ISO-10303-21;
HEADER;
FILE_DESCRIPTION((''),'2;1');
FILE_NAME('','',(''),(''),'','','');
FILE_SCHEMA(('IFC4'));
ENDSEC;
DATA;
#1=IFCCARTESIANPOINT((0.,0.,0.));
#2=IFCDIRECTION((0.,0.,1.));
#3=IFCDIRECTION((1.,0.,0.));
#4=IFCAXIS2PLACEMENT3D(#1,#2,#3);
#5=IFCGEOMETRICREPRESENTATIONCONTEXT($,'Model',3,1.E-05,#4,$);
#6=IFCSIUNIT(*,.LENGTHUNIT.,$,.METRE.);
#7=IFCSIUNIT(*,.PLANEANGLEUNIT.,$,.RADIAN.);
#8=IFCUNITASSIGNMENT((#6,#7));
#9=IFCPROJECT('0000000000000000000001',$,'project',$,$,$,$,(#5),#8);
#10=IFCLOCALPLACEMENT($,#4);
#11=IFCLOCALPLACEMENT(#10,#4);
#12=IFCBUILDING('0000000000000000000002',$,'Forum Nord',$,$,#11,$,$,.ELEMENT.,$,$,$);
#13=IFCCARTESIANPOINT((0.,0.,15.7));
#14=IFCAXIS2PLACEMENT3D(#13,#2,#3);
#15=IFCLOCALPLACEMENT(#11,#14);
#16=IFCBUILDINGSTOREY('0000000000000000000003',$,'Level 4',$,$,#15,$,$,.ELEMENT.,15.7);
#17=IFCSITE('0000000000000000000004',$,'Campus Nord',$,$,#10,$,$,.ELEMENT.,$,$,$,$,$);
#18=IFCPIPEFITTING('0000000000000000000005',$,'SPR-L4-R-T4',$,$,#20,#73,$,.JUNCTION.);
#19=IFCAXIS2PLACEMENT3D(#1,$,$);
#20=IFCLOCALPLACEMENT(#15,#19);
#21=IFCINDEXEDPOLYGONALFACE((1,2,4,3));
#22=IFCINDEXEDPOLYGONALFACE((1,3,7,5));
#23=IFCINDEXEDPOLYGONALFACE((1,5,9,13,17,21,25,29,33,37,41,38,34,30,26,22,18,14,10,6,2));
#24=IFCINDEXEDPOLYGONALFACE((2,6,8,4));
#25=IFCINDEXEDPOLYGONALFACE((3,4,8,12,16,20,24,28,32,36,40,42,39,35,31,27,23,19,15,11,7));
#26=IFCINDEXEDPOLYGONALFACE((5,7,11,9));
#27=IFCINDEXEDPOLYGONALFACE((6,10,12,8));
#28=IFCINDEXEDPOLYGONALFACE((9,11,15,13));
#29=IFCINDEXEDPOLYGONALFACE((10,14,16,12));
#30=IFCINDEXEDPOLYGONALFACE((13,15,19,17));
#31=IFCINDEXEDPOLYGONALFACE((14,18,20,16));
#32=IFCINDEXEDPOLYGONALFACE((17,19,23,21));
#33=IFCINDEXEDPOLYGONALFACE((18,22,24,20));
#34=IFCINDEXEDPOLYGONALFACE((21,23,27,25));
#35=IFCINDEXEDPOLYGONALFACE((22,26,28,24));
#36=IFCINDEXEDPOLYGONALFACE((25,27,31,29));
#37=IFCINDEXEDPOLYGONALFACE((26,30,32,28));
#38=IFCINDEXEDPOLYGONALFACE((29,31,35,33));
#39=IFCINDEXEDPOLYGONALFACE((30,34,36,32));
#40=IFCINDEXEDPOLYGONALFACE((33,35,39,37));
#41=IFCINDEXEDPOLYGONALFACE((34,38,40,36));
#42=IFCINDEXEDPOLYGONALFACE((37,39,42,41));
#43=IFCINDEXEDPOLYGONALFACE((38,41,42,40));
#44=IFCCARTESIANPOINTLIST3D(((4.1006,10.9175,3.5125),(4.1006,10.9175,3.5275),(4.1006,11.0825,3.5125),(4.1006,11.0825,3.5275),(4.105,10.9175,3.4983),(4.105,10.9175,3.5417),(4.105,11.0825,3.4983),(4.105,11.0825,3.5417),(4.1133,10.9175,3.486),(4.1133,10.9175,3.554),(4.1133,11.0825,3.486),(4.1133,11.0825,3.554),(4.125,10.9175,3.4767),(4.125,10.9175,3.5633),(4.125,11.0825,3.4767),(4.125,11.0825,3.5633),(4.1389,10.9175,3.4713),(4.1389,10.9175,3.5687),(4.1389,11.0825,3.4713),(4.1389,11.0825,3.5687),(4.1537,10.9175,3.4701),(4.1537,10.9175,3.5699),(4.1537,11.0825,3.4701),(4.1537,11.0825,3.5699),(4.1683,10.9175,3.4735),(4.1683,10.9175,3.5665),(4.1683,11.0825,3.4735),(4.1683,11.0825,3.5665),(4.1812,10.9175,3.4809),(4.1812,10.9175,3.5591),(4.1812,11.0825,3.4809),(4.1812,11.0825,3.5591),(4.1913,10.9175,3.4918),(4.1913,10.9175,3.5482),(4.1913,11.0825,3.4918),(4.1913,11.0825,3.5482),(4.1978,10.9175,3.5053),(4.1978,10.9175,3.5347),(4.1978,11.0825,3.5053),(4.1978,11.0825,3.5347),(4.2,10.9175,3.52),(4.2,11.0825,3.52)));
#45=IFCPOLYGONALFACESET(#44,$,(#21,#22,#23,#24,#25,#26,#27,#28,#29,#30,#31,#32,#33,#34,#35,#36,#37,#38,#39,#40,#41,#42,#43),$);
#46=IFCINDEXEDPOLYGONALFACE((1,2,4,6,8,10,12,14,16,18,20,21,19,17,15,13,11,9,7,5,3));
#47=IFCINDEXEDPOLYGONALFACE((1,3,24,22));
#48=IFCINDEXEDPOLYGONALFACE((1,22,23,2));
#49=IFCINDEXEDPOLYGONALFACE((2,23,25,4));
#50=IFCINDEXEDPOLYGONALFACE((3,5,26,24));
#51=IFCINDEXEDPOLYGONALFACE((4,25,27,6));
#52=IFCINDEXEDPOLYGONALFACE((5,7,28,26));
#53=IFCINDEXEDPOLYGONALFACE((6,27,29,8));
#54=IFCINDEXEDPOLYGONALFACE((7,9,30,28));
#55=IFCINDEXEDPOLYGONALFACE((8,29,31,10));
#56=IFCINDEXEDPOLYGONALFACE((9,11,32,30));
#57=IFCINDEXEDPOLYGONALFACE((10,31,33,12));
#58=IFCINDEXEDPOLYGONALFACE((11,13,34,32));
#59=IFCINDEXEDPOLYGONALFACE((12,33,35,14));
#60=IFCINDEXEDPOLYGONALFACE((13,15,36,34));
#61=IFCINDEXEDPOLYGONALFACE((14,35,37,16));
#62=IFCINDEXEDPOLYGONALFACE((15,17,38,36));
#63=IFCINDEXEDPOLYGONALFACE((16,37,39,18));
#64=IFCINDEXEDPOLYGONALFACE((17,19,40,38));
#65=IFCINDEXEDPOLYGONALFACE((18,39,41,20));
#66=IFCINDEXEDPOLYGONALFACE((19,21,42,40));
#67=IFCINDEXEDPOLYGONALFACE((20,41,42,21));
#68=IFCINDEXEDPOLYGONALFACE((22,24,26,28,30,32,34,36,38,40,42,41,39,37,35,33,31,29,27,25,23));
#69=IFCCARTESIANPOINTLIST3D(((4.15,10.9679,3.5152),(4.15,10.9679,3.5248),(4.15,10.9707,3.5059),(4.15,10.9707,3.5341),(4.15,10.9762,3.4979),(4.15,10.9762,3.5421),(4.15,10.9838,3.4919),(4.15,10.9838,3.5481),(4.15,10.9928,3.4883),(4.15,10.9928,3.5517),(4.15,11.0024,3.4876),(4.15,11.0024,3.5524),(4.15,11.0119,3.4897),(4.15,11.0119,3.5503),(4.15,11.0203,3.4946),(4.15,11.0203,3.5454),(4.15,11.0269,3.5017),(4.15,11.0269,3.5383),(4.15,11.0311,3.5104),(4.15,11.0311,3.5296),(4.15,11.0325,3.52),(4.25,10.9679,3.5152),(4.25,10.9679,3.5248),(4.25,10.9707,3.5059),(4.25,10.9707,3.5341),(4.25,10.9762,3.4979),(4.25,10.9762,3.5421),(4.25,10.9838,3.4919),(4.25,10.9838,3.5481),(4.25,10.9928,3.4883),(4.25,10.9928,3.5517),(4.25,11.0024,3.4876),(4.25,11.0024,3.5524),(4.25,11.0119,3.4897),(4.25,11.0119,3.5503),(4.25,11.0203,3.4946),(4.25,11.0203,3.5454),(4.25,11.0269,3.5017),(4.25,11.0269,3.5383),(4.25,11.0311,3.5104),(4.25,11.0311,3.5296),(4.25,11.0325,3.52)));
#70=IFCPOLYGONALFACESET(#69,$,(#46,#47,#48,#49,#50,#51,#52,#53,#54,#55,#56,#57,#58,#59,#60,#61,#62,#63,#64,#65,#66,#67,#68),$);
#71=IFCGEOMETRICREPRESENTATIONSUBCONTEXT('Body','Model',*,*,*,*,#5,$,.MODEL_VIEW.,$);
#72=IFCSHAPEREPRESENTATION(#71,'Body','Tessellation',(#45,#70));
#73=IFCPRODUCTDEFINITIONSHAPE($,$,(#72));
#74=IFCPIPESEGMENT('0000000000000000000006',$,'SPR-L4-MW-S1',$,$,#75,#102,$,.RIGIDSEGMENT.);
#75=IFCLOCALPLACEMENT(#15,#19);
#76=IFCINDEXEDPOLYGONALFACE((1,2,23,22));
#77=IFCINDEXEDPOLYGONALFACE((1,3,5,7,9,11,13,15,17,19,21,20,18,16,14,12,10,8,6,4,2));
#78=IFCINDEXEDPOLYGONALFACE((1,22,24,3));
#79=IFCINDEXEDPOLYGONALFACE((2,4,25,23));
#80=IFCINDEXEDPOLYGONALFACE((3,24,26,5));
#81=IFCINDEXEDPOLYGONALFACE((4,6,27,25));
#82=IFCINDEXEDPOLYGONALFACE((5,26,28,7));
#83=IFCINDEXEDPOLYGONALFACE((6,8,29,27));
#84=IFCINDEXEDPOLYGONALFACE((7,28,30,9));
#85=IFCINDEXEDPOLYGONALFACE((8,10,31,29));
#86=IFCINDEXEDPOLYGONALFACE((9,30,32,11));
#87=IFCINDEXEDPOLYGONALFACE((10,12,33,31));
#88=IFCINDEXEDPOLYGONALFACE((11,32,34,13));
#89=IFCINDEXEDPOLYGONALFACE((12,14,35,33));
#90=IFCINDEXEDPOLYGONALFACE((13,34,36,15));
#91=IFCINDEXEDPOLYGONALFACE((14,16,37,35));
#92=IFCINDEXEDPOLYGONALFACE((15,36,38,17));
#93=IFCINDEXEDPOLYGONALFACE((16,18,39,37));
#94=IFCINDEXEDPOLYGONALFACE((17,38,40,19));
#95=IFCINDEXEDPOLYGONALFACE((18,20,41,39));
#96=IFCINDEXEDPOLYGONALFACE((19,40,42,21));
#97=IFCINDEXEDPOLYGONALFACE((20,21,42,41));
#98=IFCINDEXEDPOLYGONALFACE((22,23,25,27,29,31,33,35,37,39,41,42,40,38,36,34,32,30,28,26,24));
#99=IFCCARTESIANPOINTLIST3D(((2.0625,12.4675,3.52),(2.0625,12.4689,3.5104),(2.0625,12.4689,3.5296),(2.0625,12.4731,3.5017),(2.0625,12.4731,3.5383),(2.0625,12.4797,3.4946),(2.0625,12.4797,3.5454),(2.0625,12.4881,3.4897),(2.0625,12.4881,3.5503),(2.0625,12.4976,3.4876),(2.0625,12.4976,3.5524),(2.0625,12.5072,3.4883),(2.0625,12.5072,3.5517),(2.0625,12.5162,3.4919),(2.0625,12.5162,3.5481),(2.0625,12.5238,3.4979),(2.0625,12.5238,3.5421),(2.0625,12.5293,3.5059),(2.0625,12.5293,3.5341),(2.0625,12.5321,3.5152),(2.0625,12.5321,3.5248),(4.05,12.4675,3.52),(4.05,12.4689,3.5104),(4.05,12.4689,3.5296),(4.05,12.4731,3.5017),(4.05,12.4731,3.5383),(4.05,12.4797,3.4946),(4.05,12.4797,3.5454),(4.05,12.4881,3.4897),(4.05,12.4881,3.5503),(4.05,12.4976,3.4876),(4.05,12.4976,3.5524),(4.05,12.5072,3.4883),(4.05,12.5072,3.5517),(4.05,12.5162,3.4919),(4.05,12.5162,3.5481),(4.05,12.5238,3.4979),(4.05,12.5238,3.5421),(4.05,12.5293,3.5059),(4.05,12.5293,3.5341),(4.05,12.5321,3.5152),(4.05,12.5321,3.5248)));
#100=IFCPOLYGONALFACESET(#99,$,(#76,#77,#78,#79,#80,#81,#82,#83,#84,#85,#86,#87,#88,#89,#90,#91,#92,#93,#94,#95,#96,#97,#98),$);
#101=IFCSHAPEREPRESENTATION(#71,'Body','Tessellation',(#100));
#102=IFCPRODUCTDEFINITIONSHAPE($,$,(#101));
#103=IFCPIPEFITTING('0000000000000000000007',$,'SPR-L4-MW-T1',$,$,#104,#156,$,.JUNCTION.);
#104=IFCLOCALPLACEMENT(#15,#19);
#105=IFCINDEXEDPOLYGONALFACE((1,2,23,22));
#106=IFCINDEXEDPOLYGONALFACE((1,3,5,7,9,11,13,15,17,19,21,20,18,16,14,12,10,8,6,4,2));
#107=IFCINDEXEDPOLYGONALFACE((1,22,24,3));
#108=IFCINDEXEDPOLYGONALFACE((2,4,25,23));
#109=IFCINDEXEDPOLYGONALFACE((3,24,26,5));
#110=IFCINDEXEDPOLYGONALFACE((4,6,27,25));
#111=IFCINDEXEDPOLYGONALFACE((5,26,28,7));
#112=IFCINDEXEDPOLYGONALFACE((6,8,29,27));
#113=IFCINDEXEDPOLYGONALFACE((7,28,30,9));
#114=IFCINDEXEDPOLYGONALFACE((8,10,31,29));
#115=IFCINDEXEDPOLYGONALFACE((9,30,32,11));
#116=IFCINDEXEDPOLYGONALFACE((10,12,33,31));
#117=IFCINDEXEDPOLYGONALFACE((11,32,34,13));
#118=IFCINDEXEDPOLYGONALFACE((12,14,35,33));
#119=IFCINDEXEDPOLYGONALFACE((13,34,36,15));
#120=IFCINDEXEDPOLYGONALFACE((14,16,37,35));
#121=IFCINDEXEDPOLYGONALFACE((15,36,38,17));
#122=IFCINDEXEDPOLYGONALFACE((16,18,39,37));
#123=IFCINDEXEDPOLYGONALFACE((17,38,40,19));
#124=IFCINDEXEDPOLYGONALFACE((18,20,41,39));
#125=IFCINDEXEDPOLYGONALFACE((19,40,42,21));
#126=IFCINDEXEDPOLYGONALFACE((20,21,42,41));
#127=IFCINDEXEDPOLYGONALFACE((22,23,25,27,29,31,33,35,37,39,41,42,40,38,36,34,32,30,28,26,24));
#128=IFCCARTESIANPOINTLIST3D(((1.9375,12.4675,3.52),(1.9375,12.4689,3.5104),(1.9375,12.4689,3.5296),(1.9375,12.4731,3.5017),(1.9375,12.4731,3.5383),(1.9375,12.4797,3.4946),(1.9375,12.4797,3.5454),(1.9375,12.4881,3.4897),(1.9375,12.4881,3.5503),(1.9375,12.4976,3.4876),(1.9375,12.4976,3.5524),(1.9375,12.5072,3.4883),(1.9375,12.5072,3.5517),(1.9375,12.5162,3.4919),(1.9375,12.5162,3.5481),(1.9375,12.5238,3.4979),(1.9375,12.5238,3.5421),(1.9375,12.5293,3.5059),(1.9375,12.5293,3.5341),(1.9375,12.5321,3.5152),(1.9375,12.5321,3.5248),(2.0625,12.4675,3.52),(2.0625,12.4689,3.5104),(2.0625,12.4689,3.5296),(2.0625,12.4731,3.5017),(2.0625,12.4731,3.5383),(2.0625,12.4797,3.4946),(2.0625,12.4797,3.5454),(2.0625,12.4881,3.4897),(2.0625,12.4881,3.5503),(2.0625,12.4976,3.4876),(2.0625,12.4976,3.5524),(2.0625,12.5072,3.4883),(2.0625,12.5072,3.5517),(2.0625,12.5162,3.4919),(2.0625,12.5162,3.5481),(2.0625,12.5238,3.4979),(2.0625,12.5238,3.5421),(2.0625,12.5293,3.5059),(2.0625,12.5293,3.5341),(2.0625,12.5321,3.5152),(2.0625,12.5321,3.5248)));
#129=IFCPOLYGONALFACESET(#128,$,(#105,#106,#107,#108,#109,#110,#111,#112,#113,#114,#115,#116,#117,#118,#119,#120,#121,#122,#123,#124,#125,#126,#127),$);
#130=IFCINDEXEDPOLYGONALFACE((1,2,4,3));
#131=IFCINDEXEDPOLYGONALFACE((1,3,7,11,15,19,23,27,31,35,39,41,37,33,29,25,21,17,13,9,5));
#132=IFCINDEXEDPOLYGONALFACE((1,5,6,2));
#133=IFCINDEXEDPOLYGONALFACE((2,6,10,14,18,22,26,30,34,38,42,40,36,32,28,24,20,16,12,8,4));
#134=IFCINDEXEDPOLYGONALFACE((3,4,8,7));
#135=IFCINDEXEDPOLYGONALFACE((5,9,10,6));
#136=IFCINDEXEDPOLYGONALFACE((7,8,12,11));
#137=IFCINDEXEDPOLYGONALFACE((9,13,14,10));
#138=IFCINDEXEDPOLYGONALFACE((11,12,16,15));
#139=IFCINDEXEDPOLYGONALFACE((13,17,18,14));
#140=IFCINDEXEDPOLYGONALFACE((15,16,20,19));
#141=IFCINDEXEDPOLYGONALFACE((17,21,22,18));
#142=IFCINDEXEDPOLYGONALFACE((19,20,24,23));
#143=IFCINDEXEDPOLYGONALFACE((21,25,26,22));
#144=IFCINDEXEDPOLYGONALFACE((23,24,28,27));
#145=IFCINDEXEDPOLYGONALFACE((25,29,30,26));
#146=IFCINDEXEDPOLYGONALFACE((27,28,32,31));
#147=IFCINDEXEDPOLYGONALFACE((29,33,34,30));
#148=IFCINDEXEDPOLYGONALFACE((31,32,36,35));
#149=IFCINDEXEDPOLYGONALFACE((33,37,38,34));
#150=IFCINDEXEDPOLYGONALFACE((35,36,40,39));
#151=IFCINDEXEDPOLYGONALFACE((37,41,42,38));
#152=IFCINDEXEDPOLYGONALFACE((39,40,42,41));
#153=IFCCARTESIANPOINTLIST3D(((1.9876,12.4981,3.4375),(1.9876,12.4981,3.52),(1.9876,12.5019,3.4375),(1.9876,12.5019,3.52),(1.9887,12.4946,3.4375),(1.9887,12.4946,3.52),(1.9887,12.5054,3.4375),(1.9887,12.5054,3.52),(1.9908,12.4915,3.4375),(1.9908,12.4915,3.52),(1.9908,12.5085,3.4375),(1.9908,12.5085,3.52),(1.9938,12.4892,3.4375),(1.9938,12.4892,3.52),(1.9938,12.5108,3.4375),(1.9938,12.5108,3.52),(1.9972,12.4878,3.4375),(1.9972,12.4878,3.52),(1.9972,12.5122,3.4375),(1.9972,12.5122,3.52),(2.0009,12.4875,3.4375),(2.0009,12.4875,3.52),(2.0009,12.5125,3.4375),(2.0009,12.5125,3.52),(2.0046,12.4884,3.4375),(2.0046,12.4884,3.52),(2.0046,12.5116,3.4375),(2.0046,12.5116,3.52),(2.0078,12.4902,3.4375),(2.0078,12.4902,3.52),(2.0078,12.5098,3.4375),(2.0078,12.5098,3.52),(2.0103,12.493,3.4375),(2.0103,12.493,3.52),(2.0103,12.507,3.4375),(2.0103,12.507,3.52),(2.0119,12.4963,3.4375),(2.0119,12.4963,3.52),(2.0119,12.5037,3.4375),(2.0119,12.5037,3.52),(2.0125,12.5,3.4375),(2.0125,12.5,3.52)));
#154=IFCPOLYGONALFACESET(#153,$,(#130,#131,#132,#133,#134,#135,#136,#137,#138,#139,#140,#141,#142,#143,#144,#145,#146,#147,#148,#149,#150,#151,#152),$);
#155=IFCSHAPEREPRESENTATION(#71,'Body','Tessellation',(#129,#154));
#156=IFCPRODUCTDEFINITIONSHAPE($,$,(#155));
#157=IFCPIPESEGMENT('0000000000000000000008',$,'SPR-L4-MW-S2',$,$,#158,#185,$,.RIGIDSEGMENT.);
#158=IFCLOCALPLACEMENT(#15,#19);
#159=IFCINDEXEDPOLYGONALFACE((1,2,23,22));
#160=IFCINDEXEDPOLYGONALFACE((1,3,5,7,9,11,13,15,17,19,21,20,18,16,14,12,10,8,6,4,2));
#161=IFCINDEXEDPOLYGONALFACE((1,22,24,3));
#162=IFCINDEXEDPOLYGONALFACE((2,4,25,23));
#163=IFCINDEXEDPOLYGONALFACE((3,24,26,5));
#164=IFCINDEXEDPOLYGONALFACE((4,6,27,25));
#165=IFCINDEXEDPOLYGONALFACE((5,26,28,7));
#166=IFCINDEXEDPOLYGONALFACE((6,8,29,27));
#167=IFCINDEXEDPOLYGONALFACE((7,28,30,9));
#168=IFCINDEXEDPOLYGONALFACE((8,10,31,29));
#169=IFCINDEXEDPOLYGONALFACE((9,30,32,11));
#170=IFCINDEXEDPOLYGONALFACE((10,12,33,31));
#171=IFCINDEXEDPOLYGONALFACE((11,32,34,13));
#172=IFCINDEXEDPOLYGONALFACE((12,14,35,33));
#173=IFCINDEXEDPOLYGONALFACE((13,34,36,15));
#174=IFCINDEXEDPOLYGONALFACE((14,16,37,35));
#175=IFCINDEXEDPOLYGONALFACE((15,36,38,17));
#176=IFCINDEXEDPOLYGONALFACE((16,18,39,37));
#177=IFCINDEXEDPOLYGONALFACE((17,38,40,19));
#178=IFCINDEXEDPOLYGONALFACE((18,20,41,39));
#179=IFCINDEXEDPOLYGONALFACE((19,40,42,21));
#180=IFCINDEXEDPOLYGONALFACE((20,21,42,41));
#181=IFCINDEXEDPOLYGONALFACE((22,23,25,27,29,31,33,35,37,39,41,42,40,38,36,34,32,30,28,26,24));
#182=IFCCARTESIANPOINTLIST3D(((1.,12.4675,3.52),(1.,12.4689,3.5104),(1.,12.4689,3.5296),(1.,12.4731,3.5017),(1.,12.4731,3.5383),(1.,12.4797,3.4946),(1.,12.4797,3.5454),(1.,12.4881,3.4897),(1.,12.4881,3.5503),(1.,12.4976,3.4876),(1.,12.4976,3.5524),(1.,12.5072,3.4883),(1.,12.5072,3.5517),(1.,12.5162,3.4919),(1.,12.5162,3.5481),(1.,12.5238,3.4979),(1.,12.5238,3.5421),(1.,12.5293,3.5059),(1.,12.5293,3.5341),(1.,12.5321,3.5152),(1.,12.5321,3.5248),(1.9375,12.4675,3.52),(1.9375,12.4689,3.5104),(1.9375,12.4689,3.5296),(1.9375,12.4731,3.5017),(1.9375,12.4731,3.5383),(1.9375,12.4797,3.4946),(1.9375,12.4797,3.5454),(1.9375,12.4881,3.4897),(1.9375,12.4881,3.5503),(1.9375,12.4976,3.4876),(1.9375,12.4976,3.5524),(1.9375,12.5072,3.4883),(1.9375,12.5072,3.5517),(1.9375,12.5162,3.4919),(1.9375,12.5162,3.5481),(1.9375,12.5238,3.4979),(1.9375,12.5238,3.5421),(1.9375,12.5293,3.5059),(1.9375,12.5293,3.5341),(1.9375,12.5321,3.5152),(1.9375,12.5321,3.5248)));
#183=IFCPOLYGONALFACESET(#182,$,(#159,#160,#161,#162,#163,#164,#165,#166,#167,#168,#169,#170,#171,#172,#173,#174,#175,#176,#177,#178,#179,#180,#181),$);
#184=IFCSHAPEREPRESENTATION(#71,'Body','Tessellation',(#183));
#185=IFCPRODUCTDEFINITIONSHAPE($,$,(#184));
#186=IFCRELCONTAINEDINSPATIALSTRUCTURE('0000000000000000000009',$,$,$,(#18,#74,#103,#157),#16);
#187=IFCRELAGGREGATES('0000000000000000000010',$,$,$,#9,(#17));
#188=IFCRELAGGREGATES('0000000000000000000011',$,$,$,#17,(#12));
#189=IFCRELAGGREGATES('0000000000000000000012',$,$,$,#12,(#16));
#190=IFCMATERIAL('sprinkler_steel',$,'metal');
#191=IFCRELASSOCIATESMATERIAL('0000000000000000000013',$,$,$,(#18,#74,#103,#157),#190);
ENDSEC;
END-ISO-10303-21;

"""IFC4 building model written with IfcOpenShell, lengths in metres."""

from ifc_helpers import new_model, si_unit, frame, origin_with_axes, origin_2d_with_axis, place, context, subcontext, project, spatial, circle, extrude, material, element, save


model = new_model("IFC4")

# Units and contexts
model_context = context("Model", 3, precision=1e-05, world=origin_with_axes())
body_context = subcontext(model_context, "Body", "Model", "MODEL_VIEW")
ifc_project = project(units=[si_unit("LENGTHUNIT", "METRE"), si_unit("PLANEANGLEUNIT", "RADIAN")], contexts=[model_context])

# Site, building, storey
site_placement = place(None, origin_with_axes())
site = spatial("IfcSite", under=ifc_project, at=site_placement, Name="Campus Nord", CompositionType="ELEMENT")
building_placement = place(site_placement, origin_with_axes())
building = spatial("IfcBuilding", under=site, at=building_placement, Name="Forum Nord", CompositionType="ELEMENT")
storey_placement = place(building_placement, frame((0.0, 0.0, 15.7), z_axis=(0.0, 0.0, 1.0), x_axis=(1.0, 0.0, 0.0)))
storey = spatial("IfcBuildingStorey", under=building, at=storey_placement, Name="Level 4", CompositionType="ELEMENT", Elevation=15.7)

# Shared definitions
ifc_material_1 = material(Name="sprinkler_steel", Category="metal")

# Pipe fitting
pipe_fitting_1_placement = place(storey_placement, frame((4.15, 11.0825, 3.52), z_axis=(0.0, -1.0, 0.0), x_axis=(1.0, 0.0, 0.0)))
element("IfcPipeFitting", 1, at=pipe_fitting_1_placement, inside=storey, material=ifc_material_1, Name="SPR-L4-R-T4", PredefinedType="JUNCTION", context=body_context, shape_type="SweptSolid", body=[
    extrude(circle(Radius=0.05, at=origin_2d_with_axis()), origin_with_axes(), (0.0, 0.0, 1.0), 0.165),
    extrude(circle(Radius=0.0325, at=origin_2d_with_axis()), frame((0.0, 0.0, 0.0825), z_axis=(1.0, 0.0, 0.0), x_axis=(0.0, 0.0, -1.0)), (0.0, 0.0, 1.0), 0.1),
])

# Pipe segment
pipe_segment_1_placement = place(storey_placement, frame((4.05, 12.5, 3.52), z_axis=(-1.0, 0.0, 0.0), x_axis=(0.0, -1.0, 0.0)))
element("IfcPipeSegment", 2, at=pipe_segment_1_placement, inside=storey, material=ifc_material_1, Name="SPR-L4-MW-S1", PredefinedType="RIGIDSEGMENT", context=body_context, shape_type="SweptSolid", body=[
    extrude(circle(Radius=0.0325, at=origin_2d_with_axis()), origin_with_axes(), (0.0, 0.0, 1.0), 1.9875),
])

# Pipe fitting
pipe_fitting_2_placement = place(storey_placement, frame((2.0625, 12.5, 3.52), z_axis=(-1.0, 0.0, 0.0), x_axis=(0.0, -1.0, 0.0)))
element("IfcPipeFitting", 3, at=pipe_fitting_2_placement, inside=storey, material=ifc_material_1, Name="SPR-L4-MW-T1", PredefinedType="JUNCTION", context=body_context, shape_type="SweptSolid", body=[
    extrude(circle(Radius=0.0325, at=origin_2d_with_axis()), origin_with_axes(), (0.0, 0.0, 1.0), 0.125),
    extrude(circle(Radius=0.0125, at=origin_2d_with_axis()), frame((0.0, 0.0, 0.0625), z_axis=(0.0, -1.0, 0.0), x_axis=(0.0, 0.0, -1.0)), (0.0, 0.0, 1.0), 0.0825),
])

# Pipe segment
pipe_segment_2_placement = place(storey_placement, frame((1.9375, 12.5, 3.52), z_axis=(-1.0, 0.0, 0.0), x_axis=(0.0, -1.0, 0.0)))
element("IfcPipeSegment", 4, at=pipe_segment_2_placement, inside=storey, material=ifc_material_1, Name="SPR-L4-MW-S2", PredefinedType="RIGIDSEGMENT", context=body_context, shape_type="SweptSolid", body=[
    extrude(circle(Radius=0.0325, at=origin_2d_with_axis()), origin_with_axes(), (0.0, 0.0, 1.0), 0.9375),
])

save(model, "model.ifc")
